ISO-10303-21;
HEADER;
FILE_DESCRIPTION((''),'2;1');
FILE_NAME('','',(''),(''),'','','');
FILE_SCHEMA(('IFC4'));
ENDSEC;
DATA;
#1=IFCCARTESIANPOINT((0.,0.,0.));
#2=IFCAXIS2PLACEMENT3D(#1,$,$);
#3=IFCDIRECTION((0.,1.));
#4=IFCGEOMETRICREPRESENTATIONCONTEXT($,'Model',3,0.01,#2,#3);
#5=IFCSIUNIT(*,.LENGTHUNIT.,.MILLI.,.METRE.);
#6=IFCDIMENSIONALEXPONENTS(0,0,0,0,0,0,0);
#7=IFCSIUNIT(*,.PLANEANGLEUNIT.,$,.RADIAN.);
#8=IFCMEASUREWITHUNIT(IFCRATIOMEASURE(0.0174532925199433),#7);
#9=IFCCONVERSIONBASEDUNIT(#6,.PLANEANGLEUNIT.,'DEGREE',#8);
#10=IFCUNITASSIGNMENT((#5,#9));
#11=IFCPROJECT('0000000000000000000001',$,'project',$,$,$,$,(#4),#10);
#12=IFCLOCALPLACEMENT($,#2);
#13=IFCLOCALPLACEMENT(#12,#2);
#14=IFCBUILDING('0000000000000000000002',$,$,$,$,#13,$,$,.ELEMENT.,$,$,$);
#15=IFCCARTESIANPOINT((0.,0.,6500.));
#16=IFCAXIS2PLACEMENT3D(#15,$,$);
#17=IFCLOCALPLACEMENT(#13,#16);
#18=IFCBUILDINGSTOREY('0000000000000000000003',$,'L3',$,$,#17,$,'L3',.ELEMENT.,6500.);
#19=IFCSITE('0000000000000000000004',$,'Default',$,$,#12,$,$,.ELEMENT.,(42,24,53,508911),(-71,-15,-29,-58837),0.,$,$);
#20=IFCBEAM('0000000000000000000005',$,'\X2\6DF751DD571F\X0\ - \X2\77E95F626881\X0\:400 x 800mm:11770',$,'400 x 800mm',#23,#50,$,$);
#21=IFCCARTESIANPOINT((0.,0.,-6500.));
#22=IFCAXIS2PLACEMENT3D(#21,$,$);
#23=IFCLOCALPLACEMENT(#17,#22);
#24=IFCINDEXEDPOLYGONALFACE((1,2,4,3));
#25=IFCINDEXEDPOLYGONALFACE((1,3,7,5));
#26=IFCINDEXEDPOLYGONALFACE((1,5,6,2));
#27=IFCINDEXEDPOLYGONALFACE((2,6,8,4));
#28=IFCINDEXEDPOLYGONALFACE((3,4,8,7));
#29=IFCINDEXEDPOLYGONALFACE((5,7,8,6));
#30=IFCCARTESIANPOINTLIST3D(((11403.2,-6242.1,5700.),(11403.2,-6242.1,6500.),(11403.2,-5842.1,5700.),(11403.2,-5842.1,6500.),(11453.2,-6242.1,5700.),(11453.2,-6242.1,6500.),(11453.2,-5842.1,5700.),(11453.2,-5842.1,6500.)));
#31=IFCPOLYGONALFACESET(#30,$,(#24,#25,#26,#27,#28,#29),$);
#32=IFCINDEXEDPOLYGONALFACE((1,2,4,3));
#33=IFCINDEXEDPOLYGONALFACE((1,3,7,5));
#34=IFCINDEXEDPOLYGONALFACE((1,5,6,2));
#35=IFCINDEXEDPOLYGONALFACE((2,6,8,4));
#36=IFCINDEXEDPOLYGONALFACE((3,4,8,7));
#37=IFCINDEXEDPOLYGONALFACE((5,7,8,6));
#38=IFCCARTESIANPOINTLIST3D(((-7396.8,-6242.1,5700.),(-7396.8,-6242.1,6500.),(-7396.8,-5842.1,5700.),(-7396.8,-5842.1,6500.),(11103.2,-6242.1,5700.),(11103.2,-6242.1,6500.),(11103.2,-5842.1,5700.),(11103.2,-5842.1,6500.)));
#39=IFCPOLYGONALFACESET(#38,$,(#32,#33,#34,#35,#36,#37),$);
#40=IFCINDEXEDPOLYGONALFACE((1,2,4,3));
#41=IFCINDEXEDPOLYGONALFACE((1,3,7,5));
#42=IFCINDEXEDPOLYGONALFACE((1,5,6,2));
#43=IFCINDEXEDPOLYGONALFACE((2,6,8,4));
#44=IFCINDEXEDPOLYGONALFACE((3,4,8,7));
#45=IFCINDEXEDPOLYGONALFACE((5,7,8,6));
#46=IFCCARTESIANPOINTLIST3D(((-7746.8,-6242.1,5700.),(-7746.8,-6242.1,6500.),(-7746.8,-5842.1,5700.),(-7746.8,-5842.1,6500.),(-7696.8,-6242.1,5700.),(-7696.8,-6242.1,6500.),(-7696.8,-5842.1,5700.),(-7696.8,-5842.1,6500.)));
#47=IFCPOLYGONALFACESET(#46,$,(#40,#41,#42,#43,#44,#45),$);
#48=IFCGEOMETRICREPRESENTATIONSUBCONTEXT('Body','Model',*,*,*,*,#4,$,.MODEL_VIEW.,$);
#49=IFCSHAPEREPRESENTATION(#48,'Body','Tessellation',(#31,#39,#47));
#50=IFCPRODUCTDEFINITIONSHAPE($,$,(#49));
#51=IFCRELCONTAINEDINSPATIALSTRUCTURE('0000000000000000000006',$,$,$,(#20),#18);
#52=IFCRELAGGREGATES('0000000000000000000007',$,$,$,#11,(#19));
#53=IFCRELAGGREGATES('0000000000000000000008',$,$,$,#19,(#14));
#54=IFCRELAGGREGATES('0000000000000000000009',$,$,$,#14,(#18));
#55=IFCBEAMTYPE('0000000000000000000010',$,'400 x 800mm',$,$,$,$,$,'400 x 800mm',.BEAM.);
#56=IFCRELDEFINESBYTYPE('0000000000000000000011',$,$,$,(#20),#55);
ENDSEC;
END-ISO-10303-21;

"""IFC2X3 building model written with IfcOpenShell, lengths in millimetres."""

from ifc_helpers import new_model, entity, si_unit, converted_unit, direction, frame, frame_2d, origin, place, context, subcontext, project, spatial, rectangle, extrude, source, transform, mapped, type_object, type_shapes, element, save


model = new_model("IFC2X3")

# Units and contexts
model_context = context("Model", 3, precision=0.01, world=origin(), true_north=direction((0.0, 1.0)))
body_context = subcontext(model_context, "Body", "Model", "MODEL_VIEW")
ifc_project = project(units=[si_unit("LENGTHUNIT", "METRE", prefix="MILLI"), converted_unit("PLANEANGLEUNIT", "DEGREE", entity("IfcRatioMeasure", 0.0174532925199433), si_unit("PLANEANGLEUNIT", "RADIAN"), dimensions=[0, 0, 0, 0, 0, 0, 0])], contexts=[model_context])

# Site, building, storey
site_placement = place(None, origin())
site = spatial("IfcSite", under=ifc_project, at=site_placement, Name="Default", CompositionType="ELEMENT", RefLatitude=(42, 24, 53, 508911), RefLongitude=(-71, -15, -29, -58837), RefElevation=0.0)
building_placement = place(site_placement, origin())
building = spatial("IfcBuilding", under=site, at=building_placement, CompositionType="ELEMENT")
storey_placement = place(building_placement, frame((0.0, 0.0, 6500.0)))
storey = spatial("IfcBuildingStorey", under=building, at=storey_placement, Name="L3", LongName="L3", CompositionType="ELEMENT", Elevation=6500.0)

# Beam
beam_type_1 = type_object("IfcBeamType", Name="400 x 800mm", ElementType="400 x 800mm", PredefinedType="BEAM")
shared_shape_1 = source(origin(), body_context, "Body", "SweptSolid", [
    extrude(rectangle(XDim=50.0, YDim=400.0, at=frame_2d((0.0, 0.0), x_axis=(1.0, 0.0))), frame((11428.2, -6042.1, 5700.0), z_axis=(0.0, 0.0, 1.0), x_axis=(-1.0, 0.0, 0.0)), (0.0, 0.0, 1.0), 800.0),
    extrude(rectangle(XDim=18500.0, YDim=400.0, at=frame_2d((0.0, -66.7), x_axis=(1.0, 0.0))), frame((1853.2, -5975.5, 5700.0)), (0.0, 0.0, 1.0), 800.0),
    extrude(rectangle(XDim=50.0, YDim=400.0, at=frame_2d((0.0, 0.0), x_axis=(1.0, 0.0))), frame((-7721.8, -6042.1, 5700.0)), (0.0, 0.0, 1.0), 800.0),
])
type_shapes(beam_type_1, [shared_shape_1])
beam_1_placement = place(storey_placement, frame((0.0, 0.0, -6500.0)))
element("IfcBeam", 1, at=beam_1_placement, inside=storey, type_object=beam_type_1, Name="混凝土 - 矩形梁:400 x 800mm:11770", ObjectType="400 x 800mm", context=body_context, shape_type="MappedRepresentation", body=[
    mapped(shared_shape_1, transform((0.0, 0.0, 0.0), scale=1.0)),
])

save(model, "model.ifc")
